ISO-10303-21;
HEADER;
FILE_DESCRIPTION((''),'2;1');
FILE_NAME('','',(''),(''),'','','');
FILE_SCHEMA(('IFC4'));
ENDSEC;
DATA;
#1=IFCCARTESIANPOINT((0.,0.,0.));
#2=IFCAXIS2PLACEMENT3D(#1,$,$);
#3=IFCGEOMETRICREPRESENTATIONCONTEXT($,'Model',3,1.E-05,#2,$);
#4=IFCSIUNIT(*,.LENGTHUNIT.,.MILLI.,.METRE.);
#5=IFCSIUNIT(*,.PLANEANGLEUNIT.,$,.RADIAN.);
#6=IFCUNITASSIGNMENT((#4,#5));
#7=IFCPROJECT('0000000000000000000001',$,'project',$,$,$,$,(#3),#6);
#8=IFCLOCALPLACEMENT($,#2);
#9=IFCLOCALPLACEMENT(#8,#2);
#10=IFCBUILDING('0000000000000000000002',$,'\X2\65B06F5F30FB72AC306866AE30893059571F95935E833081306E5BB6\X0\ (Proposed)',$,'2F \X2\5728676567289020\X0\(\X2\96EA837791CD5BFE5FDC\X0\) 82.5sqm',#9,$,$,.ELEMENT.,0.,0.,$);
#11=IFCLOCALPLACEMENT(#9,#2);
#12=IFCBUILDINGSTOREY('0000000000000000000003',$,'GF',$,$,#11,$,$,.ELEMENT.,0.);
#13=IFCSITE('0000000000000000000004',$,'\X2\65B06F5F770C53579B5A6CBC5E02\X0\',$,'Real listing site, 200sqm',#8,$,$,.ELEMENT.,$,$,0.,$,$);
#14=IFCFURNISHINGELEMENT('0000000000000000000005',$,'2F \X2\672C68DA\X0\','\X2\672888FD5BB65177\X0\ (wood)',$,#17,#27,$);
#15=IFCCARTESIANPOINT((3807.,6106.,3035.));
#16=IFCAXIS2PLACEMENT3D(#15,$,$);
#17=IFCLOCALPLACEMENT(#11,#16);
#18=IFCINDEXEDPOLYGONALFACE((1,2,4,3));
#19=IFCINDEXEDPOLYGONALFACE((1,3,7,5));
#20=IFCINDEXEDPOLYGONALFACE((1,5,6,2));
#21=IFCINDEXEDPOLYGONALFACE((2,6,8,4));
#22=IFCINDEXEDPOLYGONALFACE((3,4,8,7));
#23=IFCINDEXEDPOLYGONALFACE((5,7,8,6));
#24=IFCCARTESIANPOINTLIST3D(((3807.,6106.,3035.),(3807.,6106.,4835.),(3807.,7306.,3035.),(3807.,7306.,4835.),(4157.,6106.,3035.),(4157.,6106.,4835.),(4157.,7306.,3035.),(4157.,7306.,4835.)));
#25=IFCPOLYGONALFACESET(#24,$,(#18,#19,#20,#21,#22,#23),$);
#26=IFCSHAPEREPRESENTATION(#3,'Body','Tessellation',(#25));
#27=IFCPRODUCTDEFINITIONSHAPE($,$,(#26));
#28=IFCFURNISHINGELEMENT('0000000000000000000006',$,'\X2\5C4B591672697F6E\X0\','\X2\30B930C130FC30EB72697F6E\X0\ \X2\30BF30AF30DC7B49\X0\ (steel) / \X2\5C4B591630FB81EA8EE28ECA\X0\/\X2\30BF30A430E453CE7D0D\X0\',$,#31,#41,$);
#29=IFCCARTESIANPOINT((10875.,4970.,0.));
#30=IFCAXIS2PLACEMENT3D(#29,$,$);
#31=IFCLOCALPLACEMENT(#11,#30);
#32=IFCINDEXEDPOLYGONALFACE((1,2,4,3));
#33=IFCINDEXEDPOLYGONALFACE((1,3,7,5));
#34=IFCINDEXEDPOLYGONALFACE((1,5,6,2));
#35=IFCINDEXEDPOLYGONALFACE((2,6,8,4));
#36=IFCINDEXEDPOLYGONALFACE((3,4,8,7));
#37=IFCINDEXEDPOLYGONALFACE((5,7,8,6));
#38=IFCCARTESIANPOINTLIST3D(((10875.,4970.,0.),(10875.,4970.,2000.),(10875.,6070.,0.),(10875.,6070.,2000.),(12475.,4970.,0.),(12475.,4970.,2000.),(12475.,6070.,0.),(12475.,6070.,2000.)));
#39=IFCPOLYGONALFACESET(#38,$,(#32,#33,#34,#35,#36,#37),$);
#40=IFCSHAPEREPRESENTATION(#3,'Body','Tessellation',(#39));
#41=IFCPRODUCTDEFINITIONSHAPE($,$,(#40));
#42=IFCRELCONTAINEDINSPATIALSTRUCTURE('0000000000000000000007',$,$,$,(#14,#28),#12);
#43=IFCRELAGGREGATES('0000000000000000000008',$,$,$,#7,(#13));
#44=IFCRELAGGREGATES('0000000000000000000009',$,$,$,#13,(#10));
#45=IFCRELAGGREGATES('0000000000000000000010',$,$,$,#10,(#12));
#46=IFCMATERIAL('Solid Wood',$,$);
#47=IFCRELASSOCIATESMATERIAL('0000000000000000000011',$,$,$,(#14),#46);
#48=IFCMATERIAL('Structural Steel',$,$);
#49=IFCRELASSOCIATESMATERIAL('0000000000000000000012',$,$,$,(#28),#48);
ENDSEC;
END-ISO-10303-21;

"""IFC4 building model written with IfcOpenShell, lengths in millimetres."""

from ifc_helpers import new_model, si_unit, frame, frame_2d, origin, place, context, project, spatial, rectangle, extrude, material, element, save


model = new_model("IFC4")

# Units and contexts
model_context = context("Model", 3, precision=1e-05, world=origin())
ifc_project = project(units=[si_unit("LENGTHUNIT", "METRE", prefix="MILLI"), si_unit("PLANEANGLEUNIT", "RADIAN")], contexts=[model_context])

# Site, building, storey
site_placement = place(None, origin())
site = spatial("IfcSite", under=ifc_project, at=site_placement, Name="新潟県南魚沼市", ObjectType="Real listing site, 200sqm", CompositionType="ELEMENT", RefElevation=0.0)
building_placement = place(site_placement, origin())
building = spatial("IfcBuilding", under=site, at=building_placement, Name="新潟・犬と暮らす土間広めの家 (Proposed)", ObjectType="2F 在来木造(雪荷重対応) 82.5sqm", CompositionType="ELEMENT", ElevationOfRefHeight=0.0, ElevationOfTerrain=0.0)
storey_placement = place(building_placement, origin())
storey = spatial("IfcBuildingStorey", under=building, at=storey_placement, Name="GF", CompositionType="ELEMENT", Elevation=0.0)

# Shared definitions
ifc_material_1 = material(Name="Solid Wood")

# Shared definitions
ifc_material_2 = material(Name="Structural Steel")

# Furnishing elements
furnishing_1_placement = place(storey_placement, frame((3807.0, 6106.0, 3035.0)))
element("IfcFurnishingElement", 1, at=furnishing_1_placement, inside=storey, material=ifc_material_1, Name="2F 本棚", Description="木製家具 (wood)", context=model_context, shape_type="SweptSolid", body=[
    extrude(rectangle(XDim=350.0, YDim=1200.0, at=frame_2d((175.0, 600.0))), frame((3807.0, 6106.0, 3035.0)), (0.0, 0.0, 1.0), 1800.0),
])
furnishing_2_placement = place(storey_placement, frame((10875.0, 4970.0, 0.0)))
element("IfcFurnishingElement", 2, at=furnishing_2_placement, inside=storey, material=ifc_material_2, Name="屋外物置", Description="スチール物置 タクボ等 (steel) / 屋外・自転車/タイヤ収納", context=model_context, shape_type="SweptSolid", body=[
    extrude(rectangle(XDim=1600.0, YDim=1100.0, at=frame_2d((800.0, 550.0))), frame((10875.0, 4970.0, 0.0)), (0.0, 0.0, 1.0), 2000.0),
])

save(model, "model.ifc")
